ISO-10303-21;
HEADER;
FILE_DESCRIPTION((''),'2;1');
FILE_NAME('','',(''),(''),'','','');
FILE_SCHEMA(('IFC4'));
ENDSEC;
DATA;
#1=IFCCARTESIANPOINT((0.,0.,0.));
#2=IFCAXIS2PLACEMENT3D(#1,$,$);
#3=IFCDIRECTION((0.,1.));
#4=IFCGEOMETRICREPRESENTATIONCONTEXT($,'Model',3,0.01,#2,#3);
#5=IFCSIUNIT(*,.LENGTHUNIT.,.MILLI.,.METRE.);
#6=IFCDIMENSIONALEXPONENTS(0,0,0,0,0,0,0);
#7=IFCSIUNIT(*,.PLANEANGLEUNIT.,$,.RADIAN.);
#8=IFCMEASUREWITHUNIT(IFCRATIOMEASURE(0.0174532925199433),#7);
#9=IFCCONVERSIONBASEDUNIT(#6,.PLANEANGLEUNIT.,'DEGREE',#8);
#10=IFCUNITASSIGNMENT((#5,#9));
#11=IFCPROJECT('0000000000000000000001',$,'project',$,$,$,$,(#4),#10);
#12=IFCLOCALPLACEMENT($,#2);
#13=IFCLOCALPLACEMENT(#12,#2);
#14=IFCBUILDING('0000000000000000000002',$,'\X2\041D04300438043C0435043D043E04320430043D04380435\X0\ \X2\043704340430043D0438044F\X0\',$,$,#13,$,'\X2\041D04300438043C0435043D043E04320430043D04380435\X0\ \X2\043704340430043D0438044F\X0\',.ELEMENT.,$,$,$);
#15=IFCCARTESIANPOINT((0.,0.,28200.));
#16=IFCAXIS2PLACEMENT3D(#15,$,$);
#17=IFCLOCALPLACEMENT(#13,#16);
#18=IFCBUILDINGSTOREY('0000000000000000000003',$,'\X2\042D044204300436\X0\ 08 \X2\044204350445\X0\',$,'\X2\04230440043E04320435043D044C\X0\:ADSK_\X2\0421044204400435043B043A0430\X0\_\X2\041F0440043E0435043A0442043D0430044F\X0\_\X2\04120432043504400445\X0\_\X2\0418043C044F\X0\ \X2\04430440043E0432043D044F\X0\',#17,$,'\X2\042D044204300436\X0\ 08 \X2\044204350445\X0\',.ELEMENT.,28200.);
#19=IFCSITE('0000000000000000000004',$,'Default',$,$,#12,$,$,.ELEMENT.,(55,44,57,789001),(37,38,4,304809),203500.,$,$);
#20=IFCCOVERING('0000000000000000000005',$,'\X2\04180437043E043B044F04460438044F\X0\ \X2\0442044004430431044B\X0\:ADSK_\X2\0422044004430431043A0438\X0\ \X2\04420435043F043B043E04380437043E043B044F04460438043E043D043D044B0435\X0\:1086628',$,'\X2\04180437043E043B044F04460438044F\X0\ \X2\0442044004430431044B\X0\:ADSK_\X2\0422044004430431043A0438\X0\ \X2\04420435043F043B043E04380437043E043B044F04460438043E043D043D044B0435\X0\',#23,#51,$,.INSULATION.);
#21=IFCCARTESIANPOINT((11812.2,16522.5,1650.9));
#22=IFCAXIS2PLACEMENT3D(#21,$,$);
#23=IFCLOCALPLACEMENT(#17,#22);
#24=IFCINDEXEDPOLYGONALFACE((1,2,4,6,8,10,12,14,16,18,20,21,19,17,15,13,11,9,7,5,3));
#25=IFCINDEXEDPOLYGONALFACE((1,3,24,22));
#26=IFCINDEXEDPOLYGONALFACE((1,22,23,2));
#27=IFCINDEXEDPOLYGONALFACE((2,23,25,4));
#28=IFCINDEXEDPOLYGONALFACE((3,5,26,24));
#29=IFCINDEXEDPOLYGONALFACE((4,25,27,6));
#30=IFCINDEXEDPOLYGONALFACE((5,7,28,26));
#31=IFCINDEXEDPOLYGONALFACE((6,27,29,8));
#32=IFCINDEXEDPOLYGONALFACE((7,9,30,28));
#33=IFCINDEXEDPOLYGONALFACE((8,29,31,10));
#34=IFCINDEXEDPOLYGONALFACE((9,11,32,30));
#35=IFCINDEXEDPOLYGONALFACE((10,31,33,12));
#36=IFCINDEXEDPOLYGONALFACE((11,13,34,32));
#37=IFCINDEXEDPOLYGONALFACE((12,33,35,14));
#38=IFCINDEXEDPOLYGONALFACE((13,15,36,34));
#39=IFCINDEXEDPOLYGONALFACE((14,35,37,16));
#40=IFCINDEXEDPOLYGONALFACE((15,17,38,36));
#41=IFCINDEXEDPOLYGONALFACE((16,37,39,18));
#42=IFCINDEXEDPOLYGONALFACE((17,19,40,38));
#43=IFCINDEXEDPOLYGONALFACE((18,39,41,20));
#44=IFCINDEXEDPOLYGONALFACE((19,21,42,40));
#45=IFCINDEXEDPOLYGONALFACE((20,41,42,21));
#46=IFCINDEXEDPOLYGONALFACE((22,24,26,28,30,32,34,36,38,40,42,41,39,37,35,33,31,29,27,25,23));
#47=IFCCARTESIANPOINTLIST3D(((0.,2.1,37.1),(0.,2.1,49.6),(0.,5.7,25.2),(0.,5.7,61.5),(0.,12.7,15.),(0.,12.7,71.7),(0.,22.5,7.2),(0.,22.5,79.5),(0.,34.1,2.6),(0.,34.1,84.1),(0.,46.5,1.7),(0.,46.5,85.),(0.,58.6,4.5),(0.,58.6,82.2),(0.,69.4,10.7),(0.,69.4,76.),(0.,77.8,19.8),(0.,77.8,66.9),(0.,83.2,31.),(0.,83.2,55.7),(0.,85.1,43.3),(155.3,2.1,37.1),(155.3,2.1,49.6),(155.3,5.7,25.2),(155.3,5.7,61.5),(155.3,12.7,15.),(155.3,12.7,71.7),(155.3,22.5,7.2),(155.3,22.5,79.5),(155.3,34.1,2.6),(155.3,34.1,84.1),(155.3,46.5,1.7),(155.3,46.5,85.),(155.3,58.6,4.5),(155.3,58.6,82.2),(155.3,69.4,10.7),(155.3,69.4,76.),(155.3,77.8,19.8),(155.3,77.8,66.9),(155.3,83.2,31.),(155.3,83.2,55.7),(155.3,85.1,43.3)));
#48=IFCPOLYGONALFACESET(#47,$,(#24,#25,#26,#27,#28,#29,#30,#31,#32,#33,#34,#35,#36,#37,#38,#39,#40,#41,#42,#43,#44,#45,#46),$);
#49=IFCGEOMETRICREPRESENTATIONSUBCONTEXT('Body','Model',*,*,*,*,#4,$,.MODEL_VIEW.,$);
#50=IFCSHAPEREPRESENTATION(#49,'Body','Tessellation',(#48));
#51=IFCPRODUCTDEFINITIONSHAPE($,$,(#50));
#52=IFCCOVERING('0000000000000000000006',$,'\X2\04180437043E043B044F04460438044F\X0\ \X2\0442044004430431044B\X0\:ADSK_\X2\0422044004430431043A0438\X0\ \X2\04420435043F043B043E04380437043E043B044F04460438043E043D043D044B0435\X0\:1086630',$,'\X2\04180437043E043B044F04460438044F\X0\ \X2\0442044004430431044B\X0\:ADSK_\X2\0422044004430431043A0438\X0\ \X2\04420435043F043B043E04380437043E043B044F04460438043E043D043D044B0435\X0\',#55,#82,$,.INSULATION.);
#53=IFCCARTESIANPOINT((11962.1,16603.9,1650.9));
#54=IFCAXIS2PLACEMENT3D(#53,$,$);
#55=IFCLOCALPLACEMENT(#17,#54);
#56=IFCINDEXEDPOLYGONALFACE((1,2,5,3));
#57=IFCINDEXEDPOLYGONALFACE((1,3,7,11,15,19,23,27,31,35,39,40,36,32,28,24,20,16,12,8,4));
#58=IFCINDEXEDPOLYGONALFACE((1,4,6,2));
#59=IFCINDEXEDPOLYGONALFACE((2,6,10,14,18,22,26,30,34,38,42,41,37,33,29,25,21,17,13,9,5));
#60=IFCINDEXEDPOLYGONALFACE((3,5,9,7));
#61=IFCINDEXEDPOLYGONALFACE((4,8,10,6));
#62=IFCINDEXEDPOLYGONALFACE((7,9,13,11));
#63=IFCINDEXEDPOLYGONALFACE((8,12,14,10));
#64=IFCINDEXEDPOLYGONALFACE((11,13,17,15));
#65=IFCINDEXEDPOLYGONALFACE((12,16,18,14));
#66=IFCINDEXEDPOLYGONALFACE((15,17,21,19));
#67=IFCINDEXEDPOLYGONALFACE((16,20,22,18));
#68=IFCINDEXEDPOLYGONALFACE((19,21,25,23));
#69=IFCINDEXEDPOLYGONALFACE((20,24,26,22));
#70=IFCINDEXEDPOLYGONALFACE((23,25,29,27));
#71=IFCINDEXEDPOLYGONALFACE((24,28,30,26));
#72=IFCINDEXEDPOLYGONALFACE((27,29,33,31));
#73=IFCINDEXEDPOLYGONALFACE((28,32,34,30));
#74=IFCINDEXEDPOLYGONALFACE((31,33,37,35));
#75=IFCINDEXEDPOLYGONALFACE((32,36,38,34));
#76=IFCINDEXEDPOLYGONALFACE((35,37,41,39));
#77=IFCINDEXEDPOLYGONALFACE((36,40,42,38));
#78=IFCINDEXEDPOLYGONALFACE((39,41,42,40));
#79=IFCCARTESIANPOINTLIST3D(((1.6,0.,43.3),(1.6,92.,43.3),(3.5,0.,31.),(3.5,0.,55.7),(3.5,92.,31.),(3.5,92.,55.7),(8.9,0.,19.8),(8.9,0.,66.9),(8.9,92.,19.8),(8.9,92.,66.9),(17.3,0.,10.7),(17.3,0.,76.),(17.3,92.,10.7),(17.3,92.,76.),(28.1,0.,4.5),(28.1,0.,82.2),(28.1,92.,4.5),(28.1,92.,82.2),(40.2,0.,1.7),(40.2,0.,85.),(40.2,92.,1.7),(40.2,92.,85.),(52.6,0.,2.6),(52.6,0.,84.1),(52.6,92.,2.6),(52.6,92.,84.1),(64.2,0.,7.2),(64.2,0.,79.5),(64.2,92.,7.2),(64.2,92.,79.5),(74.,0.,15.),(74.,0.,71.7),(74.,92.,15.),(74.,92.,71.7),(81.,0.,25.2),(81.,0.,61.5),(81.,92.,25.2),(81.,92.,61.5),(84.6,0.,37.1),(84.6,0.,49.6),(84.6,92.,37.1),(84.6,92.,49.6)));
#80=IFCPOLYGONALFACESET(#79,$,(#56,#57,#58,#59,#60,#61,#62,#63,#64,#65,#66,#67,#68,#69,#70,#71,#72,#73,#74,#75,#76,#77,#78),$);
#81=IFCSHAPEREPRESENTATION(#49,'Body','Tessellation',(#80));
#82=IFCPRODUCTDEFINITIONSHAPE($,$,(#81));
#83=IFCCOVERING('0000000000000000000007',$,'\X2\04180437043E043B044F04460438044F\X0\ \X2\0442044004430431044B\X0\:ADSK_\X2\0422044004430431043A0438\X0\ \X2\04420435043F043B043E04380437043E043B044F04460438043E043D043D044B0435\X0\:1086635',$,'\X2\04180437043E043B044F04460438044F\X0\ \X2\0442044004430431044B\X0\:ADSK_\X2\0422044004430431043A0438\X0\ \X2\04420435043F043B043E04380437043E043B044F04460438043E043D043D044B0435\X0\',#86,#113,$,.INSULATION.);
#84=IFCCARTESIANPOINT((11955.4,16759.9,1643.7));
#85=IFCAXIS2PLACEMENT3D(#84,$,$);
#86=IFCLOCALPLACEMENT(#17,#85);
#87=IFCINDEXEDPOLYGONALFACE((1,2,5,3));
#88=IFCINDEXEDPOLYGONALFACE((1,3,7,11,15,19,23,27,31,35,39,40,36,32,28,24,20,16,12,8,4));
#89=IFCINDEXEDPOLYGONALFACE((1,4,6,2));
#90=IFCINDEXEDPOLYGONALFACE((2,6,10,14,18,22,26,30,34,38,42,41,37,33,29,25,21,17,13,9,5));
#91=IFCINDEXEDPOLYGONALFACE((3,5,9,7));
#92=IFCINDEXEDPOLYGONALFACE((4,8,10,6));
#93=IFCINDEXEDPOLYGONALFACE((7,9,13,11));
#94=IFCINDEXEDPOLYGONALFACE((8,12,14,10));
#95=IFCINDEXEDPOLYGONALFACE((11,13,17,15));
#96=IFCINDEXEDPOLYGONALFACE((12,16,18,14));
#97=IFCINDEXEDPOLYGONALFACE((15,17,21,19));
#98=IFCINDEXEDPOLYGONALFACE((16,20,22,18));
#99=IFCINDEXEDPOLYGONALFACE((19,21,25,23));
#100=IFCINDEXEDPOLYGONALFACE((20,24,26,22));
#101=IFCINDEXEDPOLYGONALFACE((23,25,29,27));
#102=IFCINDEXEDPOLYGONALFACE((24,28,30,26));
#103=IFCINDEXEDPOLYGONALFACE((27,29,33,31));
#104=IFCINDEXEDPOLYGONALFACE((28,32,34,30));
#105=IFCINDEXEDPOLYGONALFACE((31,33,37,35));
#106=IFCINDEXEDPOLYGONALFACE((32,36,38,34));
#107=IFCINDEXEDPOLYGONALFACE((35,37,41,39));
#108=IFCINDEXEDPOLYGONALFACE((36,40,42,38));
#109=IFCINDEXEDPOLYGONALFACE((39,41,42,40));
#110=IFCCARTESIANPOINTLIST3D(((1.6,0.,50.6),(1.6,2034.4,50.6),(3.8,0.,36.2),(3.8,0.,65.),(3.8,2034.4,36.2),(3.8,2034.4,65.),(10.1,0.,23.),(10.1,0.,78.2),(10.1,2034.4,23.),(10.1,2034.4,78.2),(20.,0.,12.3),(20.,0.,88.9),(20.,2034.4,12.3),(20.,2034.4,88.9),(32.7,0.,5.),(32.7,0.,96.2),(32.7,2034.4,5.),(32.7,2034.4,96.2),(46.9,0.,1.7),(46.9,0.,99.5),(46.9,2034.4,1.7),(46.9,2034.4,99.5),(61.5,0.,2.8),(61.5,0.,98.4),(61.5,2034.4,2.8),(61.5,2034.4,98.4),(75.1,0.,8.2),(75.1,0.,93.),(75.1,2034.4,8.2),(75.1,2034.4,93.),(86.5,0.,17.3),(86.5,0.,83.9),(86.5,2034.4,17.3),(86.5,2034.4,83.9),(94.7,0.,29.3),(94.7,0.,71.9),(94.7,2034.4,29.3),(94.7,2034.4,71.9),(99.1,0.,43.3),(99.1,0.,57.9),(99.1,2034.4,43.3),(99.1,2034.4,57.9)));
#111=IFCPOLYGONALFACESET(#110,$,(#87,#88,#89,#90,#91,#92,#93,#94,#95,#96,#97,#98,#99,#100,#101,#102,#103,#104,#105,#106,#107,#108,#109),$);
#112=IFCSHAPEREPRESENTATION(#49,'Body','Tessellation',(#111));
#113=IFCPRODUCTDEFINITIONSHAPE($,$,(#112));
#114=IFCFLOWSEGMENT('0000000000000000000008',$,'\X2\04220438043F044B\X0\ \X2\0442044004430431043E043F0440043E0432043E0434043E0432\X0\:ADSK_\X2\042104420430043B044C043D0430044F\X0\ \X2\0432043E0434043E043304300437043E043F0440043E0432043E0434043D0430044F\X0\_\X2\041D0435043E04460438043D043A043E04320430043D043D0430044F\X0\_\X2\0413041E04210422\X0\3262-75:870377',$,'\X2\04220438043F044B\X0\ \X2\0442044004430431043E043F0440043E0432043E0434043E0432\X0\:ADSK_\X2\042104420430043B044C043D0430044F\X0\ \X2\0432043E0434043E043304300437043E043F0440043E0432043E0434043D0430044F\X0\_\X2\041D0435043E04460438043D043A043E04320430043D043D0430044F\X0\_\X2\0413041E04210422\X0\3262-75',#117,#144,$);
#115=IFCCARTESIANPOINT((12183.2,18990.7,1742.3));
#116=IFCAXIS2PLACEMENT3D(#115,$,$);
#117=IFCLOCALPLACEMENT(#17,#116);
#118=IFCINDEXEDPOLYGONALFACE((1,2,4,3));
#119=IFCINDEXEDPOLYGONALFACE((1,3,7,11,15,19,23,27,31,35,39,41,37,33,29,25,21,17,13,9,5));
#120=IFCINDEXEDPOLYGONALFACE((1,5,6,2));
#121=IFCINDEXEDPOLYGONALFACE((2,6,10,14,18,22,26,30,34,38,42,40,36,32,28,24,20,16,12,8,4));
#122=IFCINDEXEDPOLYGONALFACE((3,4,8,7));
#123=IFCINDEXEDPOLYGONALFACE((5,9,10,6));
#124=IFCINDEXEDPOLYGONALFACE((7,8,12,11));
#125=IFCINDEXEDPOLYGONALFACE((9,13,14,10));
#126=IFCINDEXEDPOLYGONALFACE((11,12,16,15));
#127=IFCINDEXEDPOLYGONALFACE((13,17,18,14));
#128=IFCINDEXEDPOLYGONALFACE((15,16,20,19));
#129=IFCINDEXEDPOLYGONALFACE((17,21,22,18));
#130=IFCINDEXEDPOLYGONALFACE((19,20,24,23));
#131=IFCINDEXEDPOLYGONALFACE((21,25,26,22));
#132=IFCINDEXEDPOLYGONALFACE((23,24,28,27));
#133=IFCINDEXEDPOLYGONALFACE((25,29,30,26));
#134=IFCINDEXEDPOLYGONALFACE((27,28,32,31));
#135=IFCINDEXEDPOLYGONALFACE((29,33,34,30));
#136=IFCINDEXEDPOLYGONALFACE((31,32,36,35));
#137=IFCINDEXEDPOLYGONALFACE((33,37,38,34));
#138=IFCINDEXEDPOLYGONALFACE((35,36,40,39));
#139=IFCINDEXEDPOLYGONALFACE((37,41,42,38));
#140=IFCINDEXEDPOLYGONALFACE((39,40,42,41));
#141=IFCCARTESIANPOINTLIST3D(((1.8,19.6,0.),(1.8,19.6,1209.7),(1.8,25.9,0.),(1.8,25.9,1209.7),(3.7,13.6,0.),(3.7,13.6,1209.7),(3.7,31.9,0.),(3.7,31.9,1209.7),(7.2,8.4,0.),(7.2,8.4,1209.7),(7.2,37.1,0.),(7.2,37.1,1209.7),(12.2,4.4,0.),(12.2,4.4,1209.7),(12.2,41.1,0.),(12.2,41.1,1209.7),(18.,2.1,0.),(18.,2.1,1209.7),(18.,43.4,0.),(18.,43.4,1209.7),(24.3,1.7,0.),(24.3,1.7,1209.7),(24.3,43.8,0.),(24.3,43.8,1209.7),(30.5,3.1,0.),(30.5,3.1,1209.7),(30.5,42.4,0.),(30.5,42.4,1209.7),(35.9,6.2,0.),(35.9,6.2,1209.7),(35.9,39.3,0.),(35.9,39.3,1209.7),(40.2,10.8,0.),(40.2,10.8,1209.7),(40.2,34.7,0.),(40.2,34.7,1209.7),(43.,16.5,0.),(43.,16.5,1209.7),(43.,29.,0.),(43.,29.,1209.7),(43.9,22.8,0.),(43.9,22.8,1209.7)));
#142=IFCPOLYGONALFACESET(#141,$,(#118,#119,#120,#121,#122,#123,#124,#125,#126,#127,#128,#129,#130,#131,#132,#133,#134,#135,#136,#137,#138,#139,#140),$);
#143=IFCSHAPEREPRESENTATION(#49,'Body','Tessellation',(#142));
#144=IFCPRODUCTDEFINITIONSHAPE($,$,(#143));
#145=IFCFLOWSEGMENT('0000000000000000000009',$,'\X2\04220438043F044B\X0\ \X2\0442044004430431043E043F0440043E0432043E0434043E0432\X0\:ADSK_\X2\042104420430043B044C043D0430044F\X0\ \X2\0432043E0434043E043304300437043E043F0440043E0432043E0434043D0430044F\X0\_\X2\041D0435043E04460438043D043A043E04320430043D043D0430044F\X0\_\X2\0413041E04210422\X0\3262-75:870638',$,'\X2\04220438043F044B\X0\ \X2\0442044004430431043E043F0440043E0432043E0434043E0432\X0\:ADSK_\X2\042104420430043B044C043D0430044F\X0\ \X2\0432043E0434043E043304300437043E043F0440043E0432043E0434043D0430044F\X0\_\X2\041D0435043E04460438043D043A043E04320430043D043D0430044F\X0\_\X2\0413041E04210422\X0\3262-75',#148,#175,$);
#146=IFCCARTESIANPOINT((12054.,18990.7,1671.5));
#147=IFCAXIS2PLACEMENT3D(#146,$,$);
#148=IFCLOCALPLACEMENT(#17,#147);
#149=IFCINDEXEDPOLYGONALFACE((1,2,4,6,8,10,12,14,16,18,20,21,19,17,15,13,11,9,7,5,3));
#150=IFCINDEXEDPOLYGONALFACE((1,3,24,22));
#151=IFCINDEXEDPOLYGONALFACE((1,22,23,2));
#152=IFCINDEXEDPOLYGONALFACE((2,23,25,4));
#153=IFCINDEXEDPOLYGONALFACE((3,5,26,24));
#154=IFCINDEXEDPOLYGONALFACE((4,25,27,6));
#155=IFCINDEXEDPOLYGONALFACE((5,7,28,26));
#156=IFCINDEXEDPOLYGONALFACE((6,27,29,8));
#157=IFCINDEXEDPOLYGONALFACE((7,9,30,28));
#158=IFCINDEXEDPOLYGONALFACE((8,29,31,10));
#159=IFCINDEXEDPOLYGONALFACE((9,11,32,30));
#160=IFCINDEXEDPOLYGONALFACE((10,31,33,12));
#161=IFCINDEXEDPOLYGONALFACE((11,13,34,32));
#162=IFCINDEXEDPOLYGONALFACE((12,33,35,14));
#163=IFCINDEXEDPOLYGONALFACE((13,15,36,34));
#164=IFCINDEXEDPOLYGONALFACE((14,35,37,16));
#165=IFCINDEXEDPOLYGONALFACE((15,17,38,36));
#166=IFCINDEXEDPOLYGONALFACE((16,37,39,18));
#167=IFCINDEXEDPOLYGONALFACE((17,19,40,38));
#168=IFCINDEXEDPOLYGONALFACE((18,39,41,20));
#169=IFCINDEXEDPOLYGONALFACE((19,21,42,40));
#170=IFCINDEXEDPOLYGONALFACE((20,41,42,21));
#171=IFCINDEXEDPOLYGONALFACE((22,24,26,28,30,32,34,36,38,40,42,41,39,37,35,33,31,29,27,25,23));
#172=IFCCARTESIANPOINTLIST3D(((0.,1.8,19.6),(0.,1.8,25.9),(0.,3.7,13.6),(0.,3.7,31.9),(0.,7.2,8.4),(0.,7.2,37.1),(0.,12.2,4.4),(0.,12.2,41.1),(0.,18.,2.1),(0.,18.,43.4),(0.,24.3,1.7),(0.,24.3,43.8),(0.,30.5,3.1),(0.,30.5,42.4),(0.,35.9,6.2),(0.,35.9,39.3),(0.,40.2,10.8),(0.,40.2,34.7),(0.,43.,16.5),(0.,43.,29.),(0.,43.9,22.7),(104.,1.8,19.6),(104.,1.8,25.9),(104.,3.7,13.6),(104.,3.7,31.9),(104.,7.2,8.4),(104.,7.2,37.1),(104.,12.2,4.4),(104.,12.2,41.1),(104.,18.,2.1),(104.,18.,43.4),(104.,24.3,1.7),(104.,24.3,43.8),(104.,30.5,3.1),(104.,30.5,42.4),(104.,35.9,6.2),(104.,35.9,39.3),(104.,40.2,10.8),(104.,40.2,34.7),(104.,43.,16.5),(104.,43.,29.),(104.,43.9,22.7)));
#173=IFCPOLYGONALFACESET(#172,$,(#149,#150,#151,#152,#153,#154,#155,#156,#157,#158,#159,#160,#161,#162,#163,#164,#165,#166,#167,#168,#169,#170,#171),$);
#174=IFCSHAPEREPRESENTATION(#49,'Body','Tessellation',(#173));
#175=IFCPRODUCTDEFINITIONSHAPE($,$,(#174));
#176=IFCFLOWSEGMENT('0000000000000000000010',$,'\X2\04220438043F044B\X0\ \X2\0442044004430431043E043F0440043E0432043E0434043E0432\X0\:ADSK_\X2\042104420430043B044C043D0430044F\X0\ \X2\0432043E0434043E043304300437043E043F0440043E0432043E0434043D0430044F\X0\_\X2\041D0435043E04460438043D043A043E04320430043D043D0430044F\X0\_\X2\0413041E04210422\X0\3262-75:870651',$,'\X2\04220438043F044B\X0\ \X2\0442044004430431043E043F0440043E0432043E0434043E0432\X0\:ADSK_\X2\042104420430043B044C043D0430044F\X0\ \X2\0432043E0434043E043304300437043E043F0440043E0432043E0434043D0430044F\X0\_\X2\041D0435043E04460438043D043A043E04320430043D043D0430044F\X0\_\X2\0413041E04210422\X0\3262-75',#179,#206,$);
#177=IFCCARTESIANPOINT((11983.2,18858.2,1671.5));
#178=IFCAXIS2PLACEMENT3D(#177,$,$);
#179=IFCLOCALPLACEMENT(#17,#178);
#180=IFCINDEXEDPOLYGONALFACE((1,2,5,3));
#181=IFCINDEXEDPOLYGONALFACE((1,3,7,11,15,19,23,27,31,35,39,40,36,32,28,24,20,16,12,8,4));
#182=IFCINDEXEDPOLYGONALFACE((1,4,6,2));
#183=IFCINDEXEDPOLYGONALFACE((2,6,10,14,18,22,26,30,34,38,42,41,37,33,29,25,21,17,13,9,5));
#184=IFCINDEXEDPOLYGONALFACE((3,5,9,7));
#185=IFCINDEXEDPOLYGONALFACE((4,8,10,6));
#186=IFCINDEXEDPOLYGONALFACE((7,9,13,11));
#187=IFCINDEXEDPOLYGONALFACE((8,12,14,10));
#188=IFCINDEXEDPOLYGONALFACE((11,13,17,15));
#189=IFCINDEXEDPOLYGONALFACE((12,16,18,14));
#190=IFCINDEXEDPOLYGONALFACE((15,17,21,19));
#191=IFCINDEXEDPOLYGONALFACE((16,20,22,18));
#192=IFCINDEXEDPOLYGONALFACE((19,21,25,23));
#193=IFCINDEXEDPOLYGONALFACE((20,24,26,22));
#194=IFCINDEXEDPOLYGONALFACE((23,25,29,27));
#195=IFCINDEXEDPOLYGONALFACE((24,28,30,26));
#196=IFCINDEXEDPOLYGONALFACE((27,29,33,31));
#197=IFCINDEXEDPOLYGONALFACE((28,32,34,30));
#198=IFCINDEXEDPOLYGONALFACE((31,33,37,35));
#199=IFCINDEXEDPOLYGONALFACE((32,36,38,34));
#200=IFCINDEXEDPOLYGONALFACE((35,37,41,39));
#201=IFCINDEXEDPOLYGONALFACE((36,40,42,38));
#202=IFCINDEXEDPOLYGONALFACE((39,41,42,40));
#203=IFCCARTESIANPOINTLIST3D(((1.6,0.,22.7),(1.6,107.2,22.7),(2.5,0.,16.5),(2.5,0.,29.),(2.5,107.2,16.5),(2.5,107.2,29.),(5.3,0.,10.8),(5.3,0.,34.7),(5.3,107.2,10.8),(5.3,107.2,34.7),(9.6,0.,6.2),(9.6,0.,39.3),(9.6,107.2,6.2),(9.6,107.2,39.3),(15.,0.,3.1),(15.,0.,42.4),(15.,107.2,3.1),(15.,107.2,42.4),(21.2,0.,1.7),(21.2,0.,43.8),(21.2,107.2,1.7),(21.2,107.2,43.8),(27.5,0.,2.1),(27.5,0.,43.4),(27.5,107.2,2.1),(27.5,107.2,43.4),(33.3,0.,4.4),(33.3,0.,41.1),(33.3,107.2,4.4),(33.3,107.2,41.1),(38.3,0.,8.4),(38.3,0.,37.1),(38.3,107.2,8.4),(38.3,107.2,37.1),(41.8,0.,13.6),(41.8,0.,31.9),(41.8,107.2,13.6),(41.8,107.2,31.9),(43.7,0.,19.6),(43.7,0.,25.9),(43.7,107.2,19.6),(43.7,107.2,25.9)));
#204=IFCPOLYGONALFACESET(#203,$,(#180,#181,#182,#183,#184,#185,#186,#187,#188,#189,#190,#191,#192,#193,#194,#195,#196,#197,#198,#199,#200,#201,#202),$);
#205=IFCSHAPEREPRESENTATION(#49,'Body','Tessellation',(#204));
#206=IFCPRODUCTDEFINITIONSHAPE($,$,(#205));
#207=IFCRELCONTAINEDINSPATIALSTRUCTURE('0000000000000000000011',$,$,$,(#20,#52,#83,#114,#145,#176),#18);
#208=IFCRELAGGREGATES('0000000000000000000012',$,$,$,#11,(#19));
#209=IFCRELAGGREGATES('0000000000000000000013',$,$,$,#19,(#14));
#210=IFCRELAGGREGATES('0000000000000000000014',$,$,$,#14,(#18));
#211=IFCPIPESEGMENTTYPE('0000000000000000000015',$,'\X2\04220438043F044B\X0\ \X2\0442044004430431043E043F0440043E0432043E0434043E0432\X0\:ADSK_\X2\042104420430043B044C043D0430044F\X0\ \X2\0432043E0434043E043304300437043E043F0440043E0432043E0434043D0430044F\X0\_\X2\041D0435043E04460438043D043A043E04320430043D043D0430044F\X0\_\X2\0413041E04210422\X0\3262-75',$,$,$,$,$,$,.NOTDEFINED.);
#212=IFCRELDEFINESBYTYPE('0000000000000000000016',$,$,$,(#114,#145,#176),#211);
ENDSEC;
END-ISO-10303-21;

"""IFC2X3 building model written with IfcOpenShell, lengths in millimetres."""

from ifc_helpers import new_model, entity, si_unit, converted_unit, direction, frame, origin, origin_2d_with_axis, place, context, subcontext, project, spatial, circle, extrude, type_object, element, save


model = new_model("IFC2X3")

# Units and contexts
model_context = context("Model", 3, precision=0.01, world=origin(), true_north=direction((0.0, 1.0)))
body_context = subcontext(model_context, "Body", "Model", "MODEL_VIEW")
ifc_project = project(units=[si_unit("LENGTHUNIT", "METRE", prefix="MILLI"), converted_unit("PLANEANGLEUNIT", "DEGREE", entity("IfcRatioMeasure", 0.0174532925199433), si_unit("PLANEANGLEUNIT", "RADIAN"), dimensions=[0, 0, 0, 0, 0, 0, 0])], contexts=[model_context])

# Site, building, storey
site_placement = place(None, origin())
site = spatial("IfcSite", under=ifc_project, at=site_placement, Name="Default", CompositionType="ELEMENT", RefLatitude=(55, 44, 57, 789001), RefLongitude=(37, 38, 4, 304809), RefElevation=203500.0)
building_placement = place(site_placement, origin())
building = spatial("IfcBuilding", under=site, at=building_placement, Name="Наименование здания", LongName="Наименование здания", CompositionType="ELEMENT")
storey_placement = place(building_placement, frame((0.0, 0.0, 28200.0)))
storey = spatial("IfcBuildingStorey", under=building, at=storey_placement, Name="Этаж 08 тех", ObjectType="Уровень:ADSK_Стрелка_Проектная_Вверх_Имя уровня", LongName="Этаж 08 тех", CompositionType="ELEMENT", Elevation=28200.0)

# Coverings
covering_1_placement = place(storey_placement, frame((11812.2, 16522.5, 1650.9)))
element("IfcCovering", 1, at=covering_1_placement, inside=storey, Name="Изоляция трубы:ADSK_Трубки теплоизоляционные:1086628", ObjectType="Изоляция трубы:ADSK_Трубки теплоизоляционные", PredefinedType="INSULATION", context=body_context, shape_type="SweptSolid", body=[
    extrude(circle(Radius=41.8, at=origin_2d_with_axis()), frame((0.0, 43.4, 43.4), z_axis=(1.0, 0.0, 0.0), x_axis=(0.0, 1.0, 0.0)), (0.0, 0.0, 1.0), 155.3),
])
covering_2_placement = place(storey_placement, frame((11962.1, 16603.9, 1650.9)))
element("IfcCovering", 2, at=covering_2_placement, inside=storey, Name="Изоляция трубы:ADSK_Трубки теплоизоляционные:1086630", ObjectType="Изоляция трубы:ADSK_Трубки теплоизоляционные", PredefinedType="INSULATION", context=body_context, shape_type="SweptSolid", body=[
    extrude(circle(Radius=41.8, at=origin_2d_with_axis()), frame((43.4, 0.0, 43.4), z_axis=(0.0, 1.0, 0.0), x_axis=(-1.0, 0.0, 0.0)), (0.0, 0.0, 1.0), 92.0),
])
covering_3_placement = place(storey_placement, frame((11955.4, 16759.9, 1643.7)))
element("IfcCovering", 3, at=covering_3_placement, inside=storey, Name="Изоляция трубы:ADSK_Трубки теплоизоляционные:1086635", ObjectType="Изоляция трубы:ADSK_Трубки теплоизоляционные", PredefinedType="INSULATION", context=body_context, shape_type="SweptSolid", body=[
    extrude(circle(Radius=49.0, at=origin_2d_with_axis()), frame((50.6, 0.0, 50.6), z_axis=(0.0, 1.0, 0.0), x_axis=(-1.0, 0.0, 0.0)), (0.0, 0.0, 1.0), 2034.4),
])

# Flow segments
pipe_segment_type = type_object("IfcPipeSegmentType", Name="Типы трубопроводов:ADSK_Стальная водогазопроводная_Неоцинкованная_ГОСТ3262-75", PredefinedType="NOTDEFINED")
flow_segment_1_placement = place(storey_placement, frame((12183.2, 18990.7, 1742.3)))
element("IfcFlowSegment", 4, at=flow_segment_1_placement, inside=storey, type_object=pipe_segment_type, Name="Типы трубопроводов:ADSK_Стальная водогазопроводная_Неоцинкованная_ГОСТ3262-75:870377", ObjectType="Типы трубопроводов:ADSK_Стальная водогазопроводная_Неоцинкованная_ГОСТ3262-75", context=body_context, shape_type="SweptSolid", body=[
    extrude(circle(Radius=21.1, at=origin_2d_with_axis()), frame((22.8, 22.8, 0.0)), (0.0, 0.0, 1.0), 1209.7),
])
flow_segment_2_placement = place(storey_placement, frame((12054.0, 18990.7, 1671.5)))
element("IfcFlowSegment", 5, at=flow_segment_2_placement, inside=storey, type_object=pipe_segment_type, Name="Типы трубопроводов:ADSK_Стальная водогазопроводная_Неоцинкованная_ГОСТ3262-75:870638", ObjectType="Типы трубопроводов:ADSK_Стальная водогазопроводная_Неоцинкованная_ГОСТ3262-75", context=body_context, shape_type="SweptSolid", body=[
    extrude(circle(Radius=21.1, at=origin_2d_with_axis()), frame((0.0, 22.8, 22.8), z_axis=(1.0, 0.0, 0.0), x_axis=(0.0, 1.0, 0.0)), (0.0, 0.0, 1.0), 104.0),
])
flow_segment_3_placement = place(storey_placement, frame((11983.2, 18858.2, 1671.5)))
element("IfcFlowSegment", 6, at=flow_segment_3_placement, inside=storey, type_object=pipe_segment_type, Name="Типы трубопроводов:ADSK_Стальная водогазопроводная_Неоцинкованная_ГОСТ3262-75:870651", ObjectType="Типы трубопроводов:ADSK_Стальная водогазопроводная_Неоцинкованная_ГОСТ3262-75", context=body_context, shape_type="SweptSolid", body=[
    extrude(circle(Radius=21.1, at=origin_2d_with_axis()), frame((22.8, 0.0, 22.8), z_axis=(0.0, 1.0, 0.0), x_axis=(-1.0, 0.0, 0.0)), (0.0, 0.0, 1.0), 107.2),
])

save(model, "model.ifc")
